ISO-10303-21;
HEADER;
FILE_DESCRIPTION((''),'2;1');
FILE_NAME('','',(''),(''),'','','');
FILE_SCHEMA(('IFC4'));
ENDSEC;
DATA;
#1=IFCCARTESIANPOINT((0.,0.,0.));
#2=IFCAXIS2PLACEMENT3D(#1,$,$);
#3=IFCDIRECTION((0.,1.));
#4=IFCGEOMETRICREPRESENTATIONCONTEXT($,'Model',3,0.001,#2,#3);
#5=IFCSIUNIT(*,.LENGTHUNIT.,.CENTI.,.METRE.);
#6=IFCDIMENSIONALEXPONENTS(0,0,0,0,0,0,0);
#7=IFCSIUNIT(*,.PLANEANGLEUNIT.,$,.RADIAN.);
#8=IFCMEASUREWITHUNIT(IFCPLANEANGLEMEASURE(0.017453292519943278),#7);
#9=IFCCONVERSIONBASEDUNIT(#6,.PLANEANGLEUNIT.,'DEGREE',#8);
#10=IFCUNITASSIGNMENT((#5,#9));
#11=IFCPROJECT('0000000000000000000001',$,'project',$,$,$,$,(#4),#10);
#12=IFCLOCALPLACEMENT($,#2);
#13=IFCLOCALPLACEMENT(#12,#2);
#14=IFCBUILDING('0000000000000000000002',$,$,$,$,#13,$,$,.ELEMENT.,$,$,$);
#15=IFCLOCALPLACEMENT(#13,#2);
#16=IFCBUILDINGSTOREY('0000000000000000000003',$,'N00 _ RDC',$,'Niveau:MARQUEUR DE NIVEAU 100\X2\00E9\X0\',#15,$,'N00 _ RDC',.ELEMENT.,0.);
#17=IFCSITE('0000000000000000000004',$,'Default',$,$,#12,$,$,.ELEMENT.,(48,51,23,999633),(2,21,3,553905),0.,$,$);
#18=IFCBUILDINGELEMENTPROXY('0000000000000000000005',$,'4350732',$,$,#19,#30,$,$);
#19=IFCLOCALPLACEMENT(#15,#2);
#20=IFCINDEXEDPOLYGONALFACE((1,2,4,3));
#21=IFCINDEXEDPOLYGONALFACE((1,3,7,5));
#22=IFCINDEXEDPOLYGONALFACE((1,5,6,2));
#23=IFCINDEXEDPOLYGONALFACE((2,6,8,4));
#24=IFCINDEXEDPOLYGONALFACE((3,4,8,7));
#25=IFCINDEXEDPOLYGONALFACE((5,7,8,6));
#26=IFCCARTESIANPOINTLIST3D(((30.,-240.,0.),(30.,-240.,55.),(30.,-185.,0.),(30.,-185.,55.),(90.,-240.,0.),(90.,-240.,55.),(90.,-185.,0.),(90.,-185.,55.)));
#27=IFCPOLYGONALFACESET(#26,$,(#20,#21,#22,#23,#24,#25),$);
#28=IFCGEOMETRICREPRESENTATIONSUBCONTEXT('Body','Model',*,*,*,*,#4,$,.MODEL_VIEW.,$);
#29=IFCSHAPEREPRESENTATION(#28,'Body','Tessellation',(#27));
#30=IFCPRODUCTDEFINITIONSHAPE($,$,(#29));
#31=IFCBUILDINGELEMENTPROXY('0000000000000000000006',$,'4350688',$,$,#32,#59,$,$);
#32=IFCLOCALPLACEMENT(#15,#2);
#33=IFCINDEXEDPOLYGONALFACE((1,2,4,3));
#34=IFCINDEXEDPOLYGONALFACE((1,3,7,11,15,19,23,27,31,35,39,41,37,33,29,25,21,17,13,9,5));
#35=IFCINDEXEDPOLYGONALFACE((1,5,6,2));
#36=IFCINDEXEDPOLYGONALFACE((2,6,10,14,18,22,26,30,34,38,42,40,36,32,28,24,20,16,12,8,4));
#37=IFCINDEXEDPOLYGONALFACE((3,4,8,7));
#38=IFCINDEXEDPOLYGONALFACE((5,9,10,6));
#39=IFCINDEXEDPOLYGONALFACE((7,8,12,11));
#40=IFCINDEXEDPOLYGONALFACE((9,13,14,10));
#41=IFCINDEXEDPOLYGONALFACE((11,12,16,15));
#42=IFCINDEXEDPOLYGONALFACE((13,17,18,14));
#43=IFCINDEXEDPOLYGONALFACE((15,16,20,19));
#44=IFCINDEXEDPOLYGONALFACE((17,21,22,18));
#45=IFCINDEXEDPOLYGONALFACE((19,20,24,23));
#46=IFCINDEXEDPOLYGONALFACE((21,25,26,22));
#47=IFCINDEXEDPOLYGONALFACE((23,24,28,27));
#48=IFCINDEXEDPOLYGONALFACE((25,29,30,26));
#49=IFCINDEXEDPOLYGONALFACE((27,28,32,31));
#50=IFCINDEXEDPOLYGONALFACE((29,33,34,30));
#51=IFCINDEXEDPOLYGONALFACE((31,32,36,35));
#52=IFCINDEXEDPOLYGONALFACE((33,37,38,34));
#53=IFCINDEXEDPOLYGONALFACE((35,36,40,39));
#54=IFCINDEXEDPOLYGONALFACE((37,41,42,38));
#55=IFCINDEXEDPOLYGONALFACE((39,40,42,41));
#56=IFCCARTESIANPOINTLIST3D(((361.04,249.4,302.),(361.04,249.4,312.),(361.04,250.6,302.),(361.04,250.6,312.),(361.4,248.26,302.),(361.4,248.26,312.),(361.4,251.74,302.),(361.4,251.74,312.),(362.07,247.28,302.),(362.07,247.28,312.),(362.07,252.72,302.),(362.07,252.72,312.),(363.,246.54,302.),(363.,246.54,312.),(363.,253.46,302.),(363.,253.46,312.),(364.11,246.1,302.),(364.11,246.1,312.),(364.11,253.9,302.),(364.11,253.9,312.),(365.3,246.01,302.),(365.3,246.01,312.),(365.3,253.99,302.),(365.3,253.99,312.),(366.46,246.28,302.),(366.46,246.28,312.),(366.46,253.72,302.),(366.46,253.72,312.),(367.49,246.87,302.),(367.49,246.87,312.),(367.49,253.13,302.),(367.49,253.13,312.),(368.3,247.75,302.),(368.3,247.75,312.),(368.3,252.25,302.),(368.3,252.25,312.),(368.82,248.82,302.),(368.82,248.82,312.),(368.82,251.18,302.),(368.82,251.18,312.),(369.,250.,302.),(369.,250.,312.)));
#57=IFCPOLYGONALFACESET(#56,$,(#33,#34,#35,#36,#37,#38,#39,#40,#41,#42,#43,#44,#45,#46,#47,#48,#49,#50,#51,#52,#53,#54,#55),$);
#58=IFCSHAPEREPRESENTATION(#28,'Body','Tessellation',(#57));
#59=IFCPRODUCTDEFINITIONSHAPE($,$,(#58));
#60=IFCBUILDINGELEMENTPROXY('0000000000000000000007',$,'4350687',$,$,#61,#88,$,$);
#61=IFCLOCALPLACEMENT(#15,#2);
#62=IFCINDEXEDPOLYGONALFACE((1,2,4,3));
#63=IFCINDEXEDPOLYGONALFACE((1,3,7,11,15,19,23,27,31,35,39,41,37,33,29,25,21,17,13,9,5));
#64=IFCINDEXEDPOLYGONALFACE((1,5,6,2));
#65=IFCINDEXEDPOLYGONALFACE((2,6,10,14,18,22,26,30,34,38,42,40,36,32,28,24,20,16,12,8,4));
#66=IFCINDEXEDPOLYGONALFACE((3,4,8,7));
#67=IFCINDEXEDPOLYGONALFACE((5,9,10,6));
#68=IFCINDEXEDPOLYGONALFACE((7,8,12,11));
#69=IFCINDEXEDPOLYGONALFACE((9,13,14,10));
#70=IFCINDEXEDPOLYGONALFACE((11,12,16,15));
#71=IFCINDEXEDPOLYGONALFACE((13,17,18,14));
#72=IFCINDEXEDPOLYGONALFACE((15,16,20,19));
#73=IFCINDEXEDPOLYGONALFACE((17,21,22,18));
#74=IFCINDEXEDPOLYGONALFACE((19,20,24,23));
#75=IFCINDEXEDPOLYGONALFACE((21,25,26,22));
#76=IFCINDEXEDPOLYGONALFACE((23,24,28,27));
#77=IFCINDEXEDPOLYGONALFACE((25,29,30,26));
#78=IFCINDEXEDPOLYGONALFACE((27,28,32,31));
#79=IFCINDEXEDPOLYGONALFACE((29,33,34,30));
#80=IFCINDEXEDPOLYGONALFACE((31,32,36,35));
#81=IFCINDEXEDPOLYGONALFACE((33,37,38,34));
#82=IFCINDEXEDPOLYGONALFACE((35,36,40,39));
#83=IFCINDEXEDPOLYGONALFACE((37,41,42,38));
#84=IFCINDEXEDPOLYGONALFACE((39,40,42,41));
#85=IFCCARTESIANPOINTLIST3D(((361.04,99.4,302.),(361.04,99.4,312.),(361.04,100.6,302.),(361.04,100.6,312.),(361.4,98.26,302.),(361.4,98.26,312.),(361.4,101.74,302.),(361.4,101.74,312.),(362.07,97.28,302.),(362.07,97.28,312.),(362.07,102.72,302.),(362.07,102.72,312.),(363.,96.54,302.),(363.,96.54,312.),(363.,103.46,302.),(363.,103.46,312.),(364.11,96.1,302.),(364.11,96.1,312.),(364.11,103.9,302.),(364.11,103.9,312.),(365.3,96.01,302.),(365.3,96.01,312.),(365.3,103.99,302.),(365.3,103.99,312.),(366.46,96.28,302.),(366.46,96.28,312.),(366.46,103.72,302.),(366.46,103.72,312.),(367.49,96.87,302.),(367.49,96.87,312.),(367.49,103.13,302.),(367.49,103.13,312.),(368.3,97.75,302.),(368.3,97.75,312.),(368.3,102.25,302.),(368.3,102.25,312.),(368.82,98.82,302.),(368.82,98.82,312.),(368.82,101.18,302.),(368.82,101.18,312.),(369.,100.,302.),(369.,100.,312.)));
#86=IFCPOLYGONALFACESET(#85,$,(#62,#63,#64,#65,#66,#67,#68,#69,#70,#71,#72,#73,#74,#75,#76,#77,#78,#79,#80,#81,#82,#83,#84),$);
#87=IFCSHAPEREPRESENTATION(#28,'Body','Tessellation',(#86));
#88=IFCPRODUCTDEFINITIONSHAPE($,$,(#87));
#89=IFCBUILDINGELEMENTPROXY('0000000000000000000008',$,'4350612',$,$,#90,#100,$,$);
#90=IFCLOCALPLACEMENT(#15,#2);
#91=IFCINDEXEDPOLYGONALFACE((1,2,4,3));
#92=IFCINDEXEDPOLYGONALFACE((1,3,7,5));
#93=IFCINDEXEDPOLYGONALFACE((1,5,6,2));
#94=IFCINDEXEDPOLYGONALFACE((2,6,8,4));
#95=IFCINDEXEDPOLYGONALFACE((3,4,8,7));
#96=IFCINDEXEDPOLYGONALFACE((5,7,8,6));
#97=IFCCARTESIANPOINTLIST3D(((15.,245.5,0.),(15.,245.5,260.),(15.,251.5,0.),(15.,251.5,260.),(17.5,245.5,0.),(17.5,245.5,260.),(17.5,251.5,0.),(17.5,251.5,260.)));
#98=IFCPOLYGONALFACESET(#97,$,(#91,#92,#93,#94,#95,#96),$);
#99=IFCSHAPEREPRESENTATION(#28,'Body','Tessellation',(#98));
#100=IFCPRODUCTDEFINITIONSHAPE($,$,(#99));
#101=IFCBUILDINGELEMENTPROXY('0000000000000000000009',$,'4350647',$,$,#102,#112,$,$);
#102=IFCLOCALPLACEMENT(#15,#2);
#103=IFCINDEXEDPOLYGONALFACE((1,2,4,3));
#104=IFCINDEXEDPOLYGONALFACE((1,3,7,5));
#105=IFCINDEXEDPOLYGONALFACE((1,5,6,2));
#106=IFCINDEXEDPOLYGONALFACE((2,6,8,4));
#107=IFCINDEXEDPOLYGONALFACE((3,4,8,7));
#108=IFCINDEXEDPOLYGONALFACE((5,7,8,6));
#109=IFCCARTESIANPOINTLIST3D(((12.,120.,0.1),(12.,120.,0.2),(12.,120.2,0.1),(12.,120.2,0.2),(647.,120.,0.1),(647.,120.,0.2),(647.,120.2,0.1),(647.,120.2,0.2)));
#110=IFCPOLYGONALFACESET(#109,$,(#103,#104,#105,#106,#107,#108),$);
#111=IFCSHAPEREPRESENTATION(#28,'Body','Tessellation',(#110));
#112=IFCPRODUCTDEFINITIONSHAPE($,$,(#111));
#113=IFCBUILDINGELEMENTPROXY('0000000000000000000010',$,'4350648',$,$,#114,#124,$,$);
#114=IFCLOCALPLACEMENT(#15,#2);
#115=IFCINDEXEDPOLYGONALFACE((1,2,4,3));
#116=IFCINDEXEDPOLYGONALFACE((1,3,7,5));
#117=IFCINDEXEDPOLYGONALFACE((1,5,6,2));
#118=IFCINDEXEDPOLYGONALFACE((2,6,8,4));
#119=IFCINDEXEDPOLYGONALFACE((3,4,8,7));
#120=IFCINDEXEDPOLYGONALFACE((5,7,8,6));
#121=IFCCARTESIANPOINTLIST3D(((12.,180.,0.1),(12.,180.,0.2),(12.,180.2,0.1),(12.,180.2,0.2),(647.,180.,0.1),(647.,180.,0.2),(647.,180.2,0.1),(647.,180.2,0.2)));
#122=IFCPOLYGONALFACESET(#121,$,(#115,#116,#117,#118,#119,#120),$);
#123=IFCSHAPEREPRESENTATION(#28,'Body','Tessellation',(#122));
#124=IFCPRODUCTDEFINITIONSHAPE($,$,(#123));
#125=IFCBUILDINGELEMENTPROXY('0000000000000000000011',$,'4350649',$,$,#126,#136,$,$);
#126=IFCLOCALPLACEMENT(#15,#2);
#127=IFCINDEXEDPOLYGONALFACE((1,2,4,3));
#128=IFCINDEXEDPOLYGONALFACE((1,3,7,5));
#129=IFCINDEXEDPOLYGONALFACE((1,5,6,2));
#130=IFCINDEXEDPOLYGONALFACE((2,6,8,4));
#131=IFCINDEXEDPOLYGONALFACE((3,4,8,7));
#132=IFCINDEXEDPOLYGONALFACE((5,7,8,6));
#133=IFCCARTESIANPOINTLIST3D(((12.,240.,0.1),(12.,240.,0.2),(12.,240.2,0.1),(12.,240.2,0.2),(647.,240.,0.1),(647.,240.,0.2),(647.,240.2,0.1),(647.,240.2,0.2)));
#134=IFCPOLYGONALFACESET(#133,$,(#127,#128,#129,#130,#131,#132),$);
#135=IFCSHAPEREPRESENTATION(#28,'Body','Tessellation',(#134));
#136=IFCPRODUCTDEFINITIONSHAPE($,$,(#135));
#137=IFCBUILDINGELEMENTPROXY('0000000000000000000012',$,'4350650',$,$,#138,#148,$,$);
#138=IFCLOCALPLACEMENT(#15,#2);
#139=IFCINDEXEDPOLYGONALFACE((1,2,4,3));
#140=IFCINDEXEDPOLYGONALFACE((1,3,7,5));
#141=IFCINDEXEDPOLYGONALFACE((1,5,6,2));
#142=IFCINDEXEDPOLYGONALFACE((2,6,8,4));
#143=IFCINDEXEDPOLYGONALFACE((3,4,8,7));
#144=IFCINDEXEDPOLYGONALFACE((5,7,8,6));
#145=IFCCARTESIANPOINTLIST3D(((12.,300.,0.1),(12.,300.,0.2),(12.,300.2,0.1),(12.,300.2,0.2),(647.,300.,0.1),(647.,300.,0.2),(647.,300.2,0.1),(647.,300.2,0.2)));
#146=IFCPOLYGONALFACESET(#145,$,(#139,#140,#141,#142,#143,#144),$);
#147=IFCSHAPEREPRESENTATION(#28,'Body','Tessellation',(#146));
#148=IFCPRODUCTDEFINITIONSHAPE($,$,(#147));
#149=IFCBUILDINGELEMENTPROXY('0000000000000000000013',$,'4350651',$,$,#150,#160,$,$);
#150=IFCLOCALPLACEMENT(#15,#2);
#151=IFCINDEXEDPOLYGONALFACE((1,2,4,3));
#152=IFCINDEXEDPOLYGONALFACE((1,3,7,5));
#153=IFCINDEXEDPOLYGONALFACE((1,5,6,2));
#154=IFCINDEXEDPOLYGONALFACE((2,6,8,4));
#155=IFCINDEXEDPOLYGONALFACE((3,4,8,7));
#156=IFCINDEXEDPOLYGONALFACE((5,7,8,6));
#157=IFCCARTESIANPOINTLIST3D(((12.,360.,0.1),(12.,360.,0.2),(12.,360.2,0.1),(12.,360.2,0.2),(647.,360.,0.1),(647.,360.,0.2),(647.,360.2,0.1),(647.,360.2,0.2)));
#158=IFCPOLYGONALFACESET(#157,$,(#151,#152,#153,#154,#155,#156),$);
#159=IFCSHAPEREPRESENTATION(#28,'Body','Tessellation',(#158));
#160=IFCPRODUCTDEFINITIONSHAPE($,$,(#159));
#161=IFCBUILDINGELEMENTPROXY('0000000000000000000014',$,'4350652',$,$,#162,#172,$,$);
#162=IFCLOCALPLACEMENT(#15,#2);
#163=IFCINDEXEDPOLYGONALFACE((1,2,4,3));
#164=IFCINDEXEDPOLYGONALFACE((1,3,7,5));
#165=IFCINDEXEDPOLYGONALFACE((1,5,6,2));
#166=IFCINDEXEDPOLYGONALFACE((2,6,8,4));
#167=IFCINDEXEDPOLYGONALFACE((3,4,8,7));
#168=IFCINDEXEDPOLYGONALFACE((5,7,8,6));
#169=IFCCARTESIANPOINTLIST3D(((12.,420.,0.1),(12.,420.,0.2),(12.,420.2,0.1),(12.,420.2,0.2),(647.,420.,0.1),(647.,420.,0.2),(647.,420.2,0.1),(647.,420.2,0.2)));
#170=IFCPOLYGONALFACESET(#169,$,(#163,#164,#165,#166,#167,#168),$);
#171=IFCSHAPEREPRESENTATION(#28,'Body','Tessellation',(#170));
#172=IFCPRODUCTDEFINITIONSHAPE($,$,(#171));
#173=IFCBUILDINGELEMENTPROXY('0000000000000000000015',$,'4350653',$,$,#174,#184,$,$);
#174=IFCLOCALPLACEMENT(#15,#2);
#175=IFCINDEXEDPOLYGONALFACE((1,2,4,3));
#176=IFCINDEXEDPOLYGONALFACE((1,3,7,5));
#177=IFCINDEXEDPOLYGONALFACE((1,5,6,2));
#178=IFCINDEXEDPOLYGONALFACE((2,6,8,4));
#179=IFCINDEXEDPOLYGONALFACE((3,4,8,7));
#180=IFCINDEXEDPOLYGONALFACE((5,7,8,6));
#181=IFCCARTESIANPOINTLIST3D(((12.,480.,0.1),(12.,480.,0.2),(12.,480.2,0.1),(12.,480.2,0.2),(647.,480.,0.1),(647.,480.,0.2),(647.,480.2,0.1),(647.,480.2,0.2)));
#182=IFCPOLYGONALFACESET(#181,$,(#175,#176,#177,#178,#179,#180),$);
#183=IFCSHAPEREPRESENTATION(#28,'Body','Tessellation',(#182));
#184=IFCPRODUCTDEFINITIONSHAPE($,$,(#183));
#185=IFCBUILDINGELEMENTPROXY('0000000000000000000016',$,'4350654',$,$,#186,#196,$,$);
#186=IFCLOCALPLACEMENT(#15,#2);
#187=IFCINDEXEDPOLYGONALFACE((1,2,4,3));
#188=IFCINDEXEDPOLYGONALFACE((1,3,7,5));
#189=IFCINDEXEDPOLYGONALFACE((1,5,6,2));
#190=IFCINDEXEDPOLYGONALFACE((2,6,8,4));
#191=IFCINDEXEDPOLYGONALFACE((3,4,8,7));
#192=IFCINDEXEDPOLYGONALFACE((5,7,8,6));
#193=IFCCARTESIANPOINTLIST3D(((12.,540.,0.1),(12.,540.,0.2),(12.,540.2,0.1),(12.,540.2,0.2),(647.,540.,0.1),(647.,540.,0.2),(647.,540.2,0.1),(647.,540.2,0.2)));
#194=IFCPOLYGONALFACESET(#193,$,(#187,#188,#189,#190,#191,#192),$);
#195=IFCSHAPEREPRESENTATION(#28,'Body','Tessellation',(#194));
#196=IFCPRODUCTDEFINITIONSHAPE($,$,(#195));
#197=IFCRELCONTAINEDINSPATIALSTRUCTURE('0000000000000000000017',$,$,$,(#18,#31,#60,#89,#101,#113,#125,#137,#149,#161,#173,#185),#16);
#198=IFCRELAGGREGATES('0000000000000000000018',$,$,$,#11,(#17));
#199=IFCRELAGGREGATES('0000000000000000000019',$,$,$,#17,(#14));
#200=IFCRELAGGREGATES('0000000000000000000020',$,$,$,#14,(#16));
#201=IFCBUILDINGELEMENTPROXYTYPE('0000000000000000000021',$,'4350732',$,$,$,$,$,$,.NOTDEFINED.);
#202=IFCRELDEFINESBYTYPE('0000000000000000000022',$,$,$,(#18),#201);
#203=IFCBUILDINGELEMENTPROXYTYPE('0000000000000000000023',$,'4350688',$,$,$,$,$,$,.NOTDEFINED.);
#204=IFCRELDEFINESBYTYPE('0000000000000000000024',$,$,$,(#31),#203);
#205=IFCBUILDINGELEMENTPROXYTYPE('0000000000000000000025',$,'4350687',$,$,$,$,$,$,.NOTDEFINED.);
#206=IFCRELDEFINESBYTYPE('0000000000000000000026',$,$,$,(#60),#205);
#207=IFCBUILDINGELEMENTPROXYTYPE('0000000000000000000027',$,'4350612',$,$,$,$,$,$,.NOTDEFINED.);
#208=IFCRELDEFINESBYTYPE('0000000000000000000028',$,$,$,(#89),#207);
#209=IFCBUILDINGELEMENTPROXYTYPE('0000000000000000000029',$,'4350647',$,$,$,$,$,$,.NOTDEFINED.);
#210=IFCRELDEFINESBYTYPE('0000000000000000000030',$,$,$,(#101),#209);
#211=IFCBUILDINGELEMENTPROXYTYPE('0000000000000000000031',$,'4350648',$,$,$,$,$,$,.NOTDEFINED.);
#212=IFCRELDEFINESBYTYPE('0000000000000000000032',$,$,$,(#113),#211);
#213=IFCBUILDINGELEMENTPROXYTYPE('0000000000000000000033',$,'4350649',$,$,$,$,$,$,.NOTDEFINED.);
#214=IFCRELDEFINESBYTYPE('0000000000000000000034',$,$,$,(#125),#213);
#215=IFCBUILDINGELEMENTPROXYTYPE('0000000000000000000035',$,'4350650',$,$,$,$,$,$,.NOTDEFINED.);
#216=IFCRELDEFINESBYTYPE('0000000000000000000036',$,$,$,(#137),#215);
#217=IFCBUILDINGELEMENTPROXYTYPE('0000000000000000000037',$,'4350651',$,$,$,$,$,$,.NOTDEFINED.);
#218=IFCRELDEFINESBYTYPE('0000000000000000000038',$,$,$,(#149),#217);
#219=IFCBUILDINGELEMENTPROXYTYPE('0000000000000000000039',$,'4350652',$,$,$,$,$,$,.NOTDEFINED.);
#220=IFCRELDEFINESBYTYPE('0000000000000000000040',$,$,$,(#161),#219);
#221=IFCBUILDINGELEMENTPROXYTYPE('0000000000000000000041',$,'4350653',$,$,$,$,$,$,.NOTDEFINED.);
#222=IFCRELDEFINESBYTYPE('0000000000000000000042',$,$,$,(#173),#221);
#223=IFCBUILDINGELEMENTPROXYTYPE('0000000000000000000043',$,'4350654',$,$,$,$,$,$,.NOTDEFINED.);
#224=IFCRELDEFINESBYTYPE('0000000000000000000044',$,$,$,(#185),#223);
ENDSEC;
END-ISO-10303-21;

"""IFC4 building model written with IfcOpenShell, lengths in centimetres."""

from ifc_helpers import new_model, entity, si_unit, converted_unit, direction, frame, frame_2d, origin, origin_2d_with_axis, place, context, subcontext, project, spatial, rectangle, circle, extrude, type_object, element, save


model = new_model("IFC4")

# Units and contexts
model_context = context("Model", 3, precision=0.001, world=origin(), true_north=direction((0.0, 1.0)))
body_context = subcontext(model_context, "Body", "Model", "MODEL_VIEW")
ifc_project = project(units=[si_unit("LENGTHUNIT", "METRE", prefix="CENTI"), converted_unit("PLANEANGLEUNIT", "DEGREE", entity("IfcPlaneAngleMeasure", 0.017453292519943278), si_unit("PLANEANGLEUNIT", "RADIAN"), dimensions=[0, 0, 0, 0, 0, 0, 0])], contexts=[model_context])

# Site, building, storey
site_placement = place(None, origin())
site = spatial("IfcSite", under=ifc_project, at=site_placement, Name="Default", CompositionType="ELEMENT", RefLatitude=(48, 51, 23, 999633), RefLongitude=(2, 21, 3, 553905), RefElevation=0.0)
building_placement = place(site_placement, origin())
building = spatial("IfcBuilding", under=site, at=building_placement, CompositionType="ELEMENT")
storey_placement = place(building_placement, origin())
storey = spatial("IfcBuildingStorey", under=building, at=storey_placement, Name="N00 _ RDC", ObjectType="Niveau:MARQUEUR DE NIVEAU 100é", LongName="N00 _ RDC", CompositionType="ELEMENT", Elevation=0.0)

# Building element proxies
building_element_proxy_type_1 = type_object("IfcBuildingElementProxyType", Name="4350732", PredefinedType="NOTDEFINED")
proxy_1_placement = place(storey_placement, origin())
element("IfcBuildingElementProxy", 1, at=proxy_1_placement, inside=storey, type_object=building_element_proxy_type_1, Name="4350732", context=body_context, shape_type="SweptSolid", body=[
    extrude(rectangle(XDim=60.0, YDim=55.0, at=frame_2d((0.0, 0.0), x_axis=(1.0, 0.0))), frame((60.0, -212.5, 0.0)), (0.0, 0.0, 1.0), 55.0),
])
building_element_proxy_type_2 = type_object("IfcBuildingElementProxyType", Name="4350688", PredefinedType="NOTDEFINED")
proxy_2_placement = place(storey_placement, origin())
element("IfcBuildingElementProxy", 2, at=proxy_2_placement, inside=storey, type_object=building_element_proxy_type_2, Name="4350688", context=body_context, shape_type="SweptSolid", body=[
    extrude(circle(Radius=4.0, at=origin_2d_with_axis()), frame((365.0, 250.0, 302.0)), (0.0, 0.0, 1.0), 10.0),
])
building_element_proxy_type_3 = type_object("IfcBuildingElementProxyType", Name="4350687", PredefinedType="NOTDEFINED")
proxy_3_placement = place(storey_placement, origin())
element("IfcBuildingElementProxy", 3, at=proxy_3_placement, inside=storey, type_object=building_element_proxy_type_3, Name="4350687", context=body_context, shape_type="SweptSolid", body=[
    extrude(circle(Radius=4.0, at=origin_2d_with_axis()), frame((365.0, 100.0, 302.0)), (0.0, 0.0, 1.0), 10.0),
])
building_element_proxy_type_4 = type_object("IfcBuildingElementProxyType", Name="4350612", PredefinedType="NOTDEFINED")
proxy_4_placement = place(storey_placement, origin())
element("IfcBuildingElementProxy", 4, at=proxy_4_placement, inside=storey, type_object=building_element_proxy_type_4, Name="4350612", context=body_context, shape_type="SweptSolid", body=[
    extrude(rectangle(XDim=2.5, YDim=6.0, at=frame_2d((0.0, 0.0), x_axis=(1.0, 0.0))), frame((16.25, 248.5, 0.0)), (0.0, 0.0, 1.0), 260.0),
])
building_element_proxy_type_5 = type_object("IfcBuildingElementProxyType", Name="4350647", PredefinedType="NOTDEFINED")
proxy_5_placement = place(storey_placement, origin())
element("IfcBuildingElementProxy", 5, at=proxy_5_placement, inside=storey, type_object=building_element_proxy_type_5, Name="4350647", context=body_context, shape_type="SweptSolid", body=[
    extrude(rectangle(XDim=635.0, YDim=0.2, at=frame_2d((0.0, 0.0), x_axis=(1.0, 0.0))), frame((329.5, 120.1, 0.1)), (0.0, 0.0, 1.0), 0.1),
])
building_element_proxy_type_6 = type_object("IfcBuildingElementProxyType", Name="4350648", PredefinedType="NOTDEFINED")
proxy_6_placement = place(storey_placement, origin())
element("IfcBuildingElementProxy", 6, at=proxy_6_placement, inside=storey, type_object=building_element_proxy_type_6, Name="4350648", context=body_context, shape_type="SweptSolid", body=[
    extrude(rectangle(XDim=635.0, YDim=0.2, at=frame_2d((0.0, 0.0), x_axis=(1.0, 0.0))), frame((329.5, 180.1, 0.1)), (0.0, 0.0, 1.0), 0.1),
])
building_element_proxy_type_7 = type_object("IfcBuildingElementProxyType", Name="4350649", PredefinedType="NOTDEFINED")
proxy_7_placement = place(storey_placement, origin())
element("IfcBuildingElementProxy", 7, at=proxy_7_placement, inside=storey, type_object=building_element_proxy_type_7, Name="4350649", context=body_context, shape_type="SweptSolid", body=[
    extrude(rectangle(XDim=635.0, YDim=0.2, at=frame_2d((0.0, 0.0), x_axis=(1.0, 0.0))), frame((329.5, 240.1, 0.1)), (0.0, 0.0, 1.0), 0.1),
])
building_element_proxy_type_8 = type_object("IfcBuildingElementProxyType", Name="4350650", PredefinedType="NOTDEFINED")
proxy_8_placement = place(storey_placement, origin())
element("IfcBuildingElementProxy", 8, at=proxy_8_placement, inside=storey, type_object=building_element_proxy_type_8, Name="4350650", context=body_context, shape_type="SweptSolid", body=[
    extrude(rectangle(XDim=635.0, YDim=0.2, at=frame_2d((0.0, 0.0), x_axis=(1.0, 0.0))), frame((329.5, 300.1, 0.1)), (0.0, 0.0, 1.0), 0.1),
])
building_element_proxy_type_9 = type_object("IfcBuildingElementProxyType", Name="4350651", PredefinedType="NOTDEFINED")
proxy_9_placement = place(storey_placement, origin())
element("IfcBuildingElementProxy", 9, at=proxy_9_placement, inside=storey, type_object=building_element_proxy_type_9, Name="4350651", context=body_context, shape_type="SweptSolid", body=[
    extrude(rectangle(XDim=635.0, YDim=0.2, at=frame_2d((0.0, 0.0), x_axis=(1.0, 0.0))), frame((329.5, 360.1, 0.1)), (0.0, 0.0, 1.0), 0.1),
])
building_element_proxy_type_10 = type_object("IfcBuildingElementProxyType", Name="4350652", PredefinedType="NOTDEFINED")
proxy_10_placement = place(storey_placement, origin())
element("IfcBuildingElementProxy", 10, at=proxy_10_placement, inside=storey, type_object=building_element_proxy_type_10, Name="4350652", context=body_context, shape_type="SweptSolid", body=[
    extrude(rectangle(XDim=635.0, YDim=0.2, at=frame_2d((0.0, 0.0), x_axis=(1.0, 0.0))), frame((329.5, 420.1, 0.1)), (0.0, 0.0, 1.0), 0.1),
])
building_element_proxy_type_11 = type_object("IfcBuildingElementProxyType", Name="4350653", PredefinedType="NOTDEFINED")
proxy_11_placement = place(storey_placement, origin())
element("IfcBuildingElementProxy", 11, at=proxy_11_placement, inside=storey, type_object=building_element_proxy_type_11, Name="4350653", context=body_context, shape_type="SweptSolid", body=[
    extrude(rectangle(XDim=635.0, YDim=0.2, at=frame_2d((0.0, 0.0), x_axis=(1.0, 0.0))), frame((329.5, 480.1, 0.1)), (0.0, 0.0, 1.0), 0.1),
])
building_element_proxy_type_12 = type_object("IfcBuildingElementProxyType", Name="4350654", PredefinedType="NOTDEFINED")
proxy_12_placement = place(storey_placement, origin())
element("IfcBuildingElementProxy", 12, at=proxy_12_placement, inside=storey, type_object=building_element_proxy_type_12, Name="4350654", context=body_context, shape_type="SweptSolid", body=[
    extrude(rectangle(XDim=635.0, YDim=0.2, at=frame_2d((0.0, 0.0), x_axis=(1.0, 0.0))), frame((329.5, 540.1, 0.1)), (0.0, 0.0, 1.0), 0.1),
])

save(model, "model.ifc")
